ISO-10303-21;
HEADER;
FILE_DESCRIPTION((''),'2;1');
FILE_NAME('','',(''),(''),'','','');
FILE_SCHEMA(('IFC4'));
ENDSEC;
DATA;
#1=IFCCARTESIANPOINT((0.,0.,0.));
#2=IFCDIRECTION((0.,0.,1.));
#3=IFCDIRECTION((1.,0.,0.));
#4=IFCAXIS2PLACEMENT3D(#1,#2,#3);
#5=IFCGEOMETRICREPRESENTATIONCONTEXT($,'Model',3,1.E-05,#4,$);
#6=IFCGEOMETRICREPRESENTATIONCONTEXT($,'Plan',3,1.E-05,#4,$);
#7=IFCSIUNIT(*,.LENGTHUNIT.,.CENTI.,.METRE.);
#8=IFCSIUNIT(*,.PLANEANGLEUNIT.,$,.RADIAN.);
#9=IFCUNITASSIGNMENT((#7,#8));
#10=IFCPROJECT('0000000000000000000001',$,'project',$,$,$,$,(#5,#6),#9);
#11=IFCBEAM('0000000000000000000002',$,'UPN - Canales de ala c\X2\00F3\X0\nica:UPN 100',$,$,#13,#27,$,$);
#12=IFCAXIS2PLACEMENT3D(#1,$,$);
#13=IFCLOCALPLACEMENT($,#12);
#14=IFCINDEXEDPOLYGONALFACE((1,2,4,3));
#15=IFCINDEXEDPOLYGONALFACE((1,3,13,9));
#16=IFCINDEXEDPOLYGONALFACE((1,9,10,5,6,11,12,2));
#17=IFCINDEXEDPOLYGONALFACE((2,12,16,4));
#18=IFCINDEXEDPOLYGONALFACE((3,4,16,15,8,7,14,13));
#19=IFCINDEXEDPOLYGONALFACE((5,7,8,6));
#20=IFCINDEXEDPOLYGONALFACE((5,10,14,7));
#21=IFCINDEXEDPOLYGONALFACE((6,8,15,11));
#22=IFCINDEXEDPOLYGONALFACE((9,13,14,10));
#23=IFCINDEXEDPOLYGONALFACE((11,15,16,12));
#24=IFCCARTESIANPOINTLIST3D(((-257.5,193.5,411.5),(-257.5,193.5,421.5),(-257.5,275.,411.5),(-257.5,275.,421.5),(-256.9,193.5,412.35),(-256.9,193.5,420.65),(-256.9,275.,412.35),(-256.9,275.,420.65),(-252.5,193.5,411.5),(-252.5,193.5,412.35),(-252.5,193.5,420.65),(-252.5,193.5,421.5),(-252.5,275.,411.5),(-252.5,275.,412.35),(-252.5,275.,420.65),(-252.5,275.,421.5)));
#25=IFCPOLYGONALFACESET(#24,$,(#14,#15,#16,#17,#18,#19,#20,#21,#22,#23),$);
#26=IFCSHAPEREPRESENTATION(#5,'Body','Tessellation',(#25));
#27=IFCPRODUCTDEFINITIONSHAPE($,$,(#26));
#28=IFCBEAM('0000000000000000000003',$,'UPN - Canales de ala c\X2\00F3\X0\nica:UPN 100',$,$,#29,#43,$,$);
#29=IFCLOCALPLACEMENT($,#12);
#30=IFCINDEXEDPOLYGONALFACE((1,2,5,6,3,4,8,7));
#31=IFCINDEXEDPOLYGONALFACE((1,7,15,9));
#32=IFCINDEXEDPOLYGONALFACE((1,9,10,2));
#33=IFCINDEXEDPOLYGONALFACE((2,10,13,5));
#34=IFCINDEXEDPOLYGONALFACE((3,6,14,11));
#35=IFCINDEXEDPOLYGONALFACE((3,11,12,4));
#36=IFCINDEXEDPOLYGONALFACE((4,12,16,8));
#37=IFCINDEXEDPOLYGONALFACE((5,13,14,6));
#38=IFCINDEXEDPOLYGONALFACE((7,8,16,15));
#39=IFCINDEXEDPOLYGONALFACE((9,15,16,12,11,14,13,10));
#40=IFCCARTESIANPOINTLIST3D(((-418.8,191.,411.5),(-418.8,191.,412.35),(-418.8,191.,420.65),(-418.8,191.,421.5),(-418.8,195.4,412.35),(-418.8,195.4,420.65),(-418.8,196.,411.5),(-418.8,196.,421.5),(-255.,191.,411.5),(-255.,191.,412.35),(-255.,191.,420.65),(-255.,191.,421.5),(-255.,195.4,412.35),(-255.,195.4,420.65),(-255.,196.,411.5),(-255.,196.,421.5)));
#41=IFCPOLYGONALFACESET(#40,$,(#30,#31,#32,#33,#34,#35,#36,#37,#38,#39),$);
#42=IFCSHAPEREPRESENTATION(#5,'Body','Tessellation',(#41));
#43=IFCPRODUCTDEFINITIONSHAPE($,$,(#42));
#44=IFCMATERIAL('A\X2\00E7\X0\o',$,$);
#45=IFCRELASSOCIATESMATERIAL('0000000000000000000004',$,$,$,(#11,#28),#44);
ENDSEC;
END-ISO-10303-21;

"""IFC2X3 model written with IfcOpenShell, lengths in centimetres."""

from ifc_helpers import new_model, si_unit, frame, origin_with_axes, origin_2d_with_axis, place, context, project, u_section, extrude, material, element, save


model = new_model("IFC2X3")

# Units and contexts
model_context = context("Model", 3, precision=1e-05, world=origin_with_axes())
plan_context = context("Plan", 3, precision=1e-05, world=origin_with_axes())
ifc_project = project(units=[si_unit("LENGTHUNIT", "METRE", prefix="CENTI"), si_unit("PLANEANGLEUNIT", "RADIAN")], contexts=[model_context, plan_context])

# Shared definitions
ifc_material = material(Name="Aço")

# Beams
beam_1_placement = place(None, frame((-255.0, 193.5, 416.5), z_axis=(0.0, 1.0, 0.0), x_axis=(1.0, 0.0, 0.0)))
element("IfcBeam", 1, at=beam_1_placement, material=ifc_material, Name="UPN - Canales de ala cónica:UPN 100", context=model_context, shape_type="SweptSolid", body=[
    extrude(u_section(Depth=10.0, FlangeWidth=5.0, WebThickness=0.6, FlangeThickness=0.85, FilletRadius=0.0, EdgeRadius=0.0, FlangeSlope=0.0, CentreOfGravityInX=0.0, at=origin_2d_with_axis()), origin_with_axes(), (0.0, 0.0, 1.0), 81.5),
])
beam_2_placement = place(None, frame((-255.0, 193.5, 416.5), z_axis=(-1.0, 0.0, 0.0), x_axis=(0.0, -1.0, 0.0)))
element("IfcBeam", 2, at=beam_2_placement, material=ifc_material, Name="UPN - Canales de ala cónica:UPN 100", context=model_context, shape_type="SweptSolid", body=[
    extrude(u_section(Depth=10.0, FlangeWidth=5.0, WebThickness=0.6, FlangeThickness=0.85, FilletRadius=0.0, EdgeRadius=0.0, FlangeSlope=0.0, CentreOfGravityInX=0.0, at=origin_2d_with_axis()), origin_with_axes(), (0.0, 0.0, 1.0), 163.8),
])

save(model, "model.ifc")
